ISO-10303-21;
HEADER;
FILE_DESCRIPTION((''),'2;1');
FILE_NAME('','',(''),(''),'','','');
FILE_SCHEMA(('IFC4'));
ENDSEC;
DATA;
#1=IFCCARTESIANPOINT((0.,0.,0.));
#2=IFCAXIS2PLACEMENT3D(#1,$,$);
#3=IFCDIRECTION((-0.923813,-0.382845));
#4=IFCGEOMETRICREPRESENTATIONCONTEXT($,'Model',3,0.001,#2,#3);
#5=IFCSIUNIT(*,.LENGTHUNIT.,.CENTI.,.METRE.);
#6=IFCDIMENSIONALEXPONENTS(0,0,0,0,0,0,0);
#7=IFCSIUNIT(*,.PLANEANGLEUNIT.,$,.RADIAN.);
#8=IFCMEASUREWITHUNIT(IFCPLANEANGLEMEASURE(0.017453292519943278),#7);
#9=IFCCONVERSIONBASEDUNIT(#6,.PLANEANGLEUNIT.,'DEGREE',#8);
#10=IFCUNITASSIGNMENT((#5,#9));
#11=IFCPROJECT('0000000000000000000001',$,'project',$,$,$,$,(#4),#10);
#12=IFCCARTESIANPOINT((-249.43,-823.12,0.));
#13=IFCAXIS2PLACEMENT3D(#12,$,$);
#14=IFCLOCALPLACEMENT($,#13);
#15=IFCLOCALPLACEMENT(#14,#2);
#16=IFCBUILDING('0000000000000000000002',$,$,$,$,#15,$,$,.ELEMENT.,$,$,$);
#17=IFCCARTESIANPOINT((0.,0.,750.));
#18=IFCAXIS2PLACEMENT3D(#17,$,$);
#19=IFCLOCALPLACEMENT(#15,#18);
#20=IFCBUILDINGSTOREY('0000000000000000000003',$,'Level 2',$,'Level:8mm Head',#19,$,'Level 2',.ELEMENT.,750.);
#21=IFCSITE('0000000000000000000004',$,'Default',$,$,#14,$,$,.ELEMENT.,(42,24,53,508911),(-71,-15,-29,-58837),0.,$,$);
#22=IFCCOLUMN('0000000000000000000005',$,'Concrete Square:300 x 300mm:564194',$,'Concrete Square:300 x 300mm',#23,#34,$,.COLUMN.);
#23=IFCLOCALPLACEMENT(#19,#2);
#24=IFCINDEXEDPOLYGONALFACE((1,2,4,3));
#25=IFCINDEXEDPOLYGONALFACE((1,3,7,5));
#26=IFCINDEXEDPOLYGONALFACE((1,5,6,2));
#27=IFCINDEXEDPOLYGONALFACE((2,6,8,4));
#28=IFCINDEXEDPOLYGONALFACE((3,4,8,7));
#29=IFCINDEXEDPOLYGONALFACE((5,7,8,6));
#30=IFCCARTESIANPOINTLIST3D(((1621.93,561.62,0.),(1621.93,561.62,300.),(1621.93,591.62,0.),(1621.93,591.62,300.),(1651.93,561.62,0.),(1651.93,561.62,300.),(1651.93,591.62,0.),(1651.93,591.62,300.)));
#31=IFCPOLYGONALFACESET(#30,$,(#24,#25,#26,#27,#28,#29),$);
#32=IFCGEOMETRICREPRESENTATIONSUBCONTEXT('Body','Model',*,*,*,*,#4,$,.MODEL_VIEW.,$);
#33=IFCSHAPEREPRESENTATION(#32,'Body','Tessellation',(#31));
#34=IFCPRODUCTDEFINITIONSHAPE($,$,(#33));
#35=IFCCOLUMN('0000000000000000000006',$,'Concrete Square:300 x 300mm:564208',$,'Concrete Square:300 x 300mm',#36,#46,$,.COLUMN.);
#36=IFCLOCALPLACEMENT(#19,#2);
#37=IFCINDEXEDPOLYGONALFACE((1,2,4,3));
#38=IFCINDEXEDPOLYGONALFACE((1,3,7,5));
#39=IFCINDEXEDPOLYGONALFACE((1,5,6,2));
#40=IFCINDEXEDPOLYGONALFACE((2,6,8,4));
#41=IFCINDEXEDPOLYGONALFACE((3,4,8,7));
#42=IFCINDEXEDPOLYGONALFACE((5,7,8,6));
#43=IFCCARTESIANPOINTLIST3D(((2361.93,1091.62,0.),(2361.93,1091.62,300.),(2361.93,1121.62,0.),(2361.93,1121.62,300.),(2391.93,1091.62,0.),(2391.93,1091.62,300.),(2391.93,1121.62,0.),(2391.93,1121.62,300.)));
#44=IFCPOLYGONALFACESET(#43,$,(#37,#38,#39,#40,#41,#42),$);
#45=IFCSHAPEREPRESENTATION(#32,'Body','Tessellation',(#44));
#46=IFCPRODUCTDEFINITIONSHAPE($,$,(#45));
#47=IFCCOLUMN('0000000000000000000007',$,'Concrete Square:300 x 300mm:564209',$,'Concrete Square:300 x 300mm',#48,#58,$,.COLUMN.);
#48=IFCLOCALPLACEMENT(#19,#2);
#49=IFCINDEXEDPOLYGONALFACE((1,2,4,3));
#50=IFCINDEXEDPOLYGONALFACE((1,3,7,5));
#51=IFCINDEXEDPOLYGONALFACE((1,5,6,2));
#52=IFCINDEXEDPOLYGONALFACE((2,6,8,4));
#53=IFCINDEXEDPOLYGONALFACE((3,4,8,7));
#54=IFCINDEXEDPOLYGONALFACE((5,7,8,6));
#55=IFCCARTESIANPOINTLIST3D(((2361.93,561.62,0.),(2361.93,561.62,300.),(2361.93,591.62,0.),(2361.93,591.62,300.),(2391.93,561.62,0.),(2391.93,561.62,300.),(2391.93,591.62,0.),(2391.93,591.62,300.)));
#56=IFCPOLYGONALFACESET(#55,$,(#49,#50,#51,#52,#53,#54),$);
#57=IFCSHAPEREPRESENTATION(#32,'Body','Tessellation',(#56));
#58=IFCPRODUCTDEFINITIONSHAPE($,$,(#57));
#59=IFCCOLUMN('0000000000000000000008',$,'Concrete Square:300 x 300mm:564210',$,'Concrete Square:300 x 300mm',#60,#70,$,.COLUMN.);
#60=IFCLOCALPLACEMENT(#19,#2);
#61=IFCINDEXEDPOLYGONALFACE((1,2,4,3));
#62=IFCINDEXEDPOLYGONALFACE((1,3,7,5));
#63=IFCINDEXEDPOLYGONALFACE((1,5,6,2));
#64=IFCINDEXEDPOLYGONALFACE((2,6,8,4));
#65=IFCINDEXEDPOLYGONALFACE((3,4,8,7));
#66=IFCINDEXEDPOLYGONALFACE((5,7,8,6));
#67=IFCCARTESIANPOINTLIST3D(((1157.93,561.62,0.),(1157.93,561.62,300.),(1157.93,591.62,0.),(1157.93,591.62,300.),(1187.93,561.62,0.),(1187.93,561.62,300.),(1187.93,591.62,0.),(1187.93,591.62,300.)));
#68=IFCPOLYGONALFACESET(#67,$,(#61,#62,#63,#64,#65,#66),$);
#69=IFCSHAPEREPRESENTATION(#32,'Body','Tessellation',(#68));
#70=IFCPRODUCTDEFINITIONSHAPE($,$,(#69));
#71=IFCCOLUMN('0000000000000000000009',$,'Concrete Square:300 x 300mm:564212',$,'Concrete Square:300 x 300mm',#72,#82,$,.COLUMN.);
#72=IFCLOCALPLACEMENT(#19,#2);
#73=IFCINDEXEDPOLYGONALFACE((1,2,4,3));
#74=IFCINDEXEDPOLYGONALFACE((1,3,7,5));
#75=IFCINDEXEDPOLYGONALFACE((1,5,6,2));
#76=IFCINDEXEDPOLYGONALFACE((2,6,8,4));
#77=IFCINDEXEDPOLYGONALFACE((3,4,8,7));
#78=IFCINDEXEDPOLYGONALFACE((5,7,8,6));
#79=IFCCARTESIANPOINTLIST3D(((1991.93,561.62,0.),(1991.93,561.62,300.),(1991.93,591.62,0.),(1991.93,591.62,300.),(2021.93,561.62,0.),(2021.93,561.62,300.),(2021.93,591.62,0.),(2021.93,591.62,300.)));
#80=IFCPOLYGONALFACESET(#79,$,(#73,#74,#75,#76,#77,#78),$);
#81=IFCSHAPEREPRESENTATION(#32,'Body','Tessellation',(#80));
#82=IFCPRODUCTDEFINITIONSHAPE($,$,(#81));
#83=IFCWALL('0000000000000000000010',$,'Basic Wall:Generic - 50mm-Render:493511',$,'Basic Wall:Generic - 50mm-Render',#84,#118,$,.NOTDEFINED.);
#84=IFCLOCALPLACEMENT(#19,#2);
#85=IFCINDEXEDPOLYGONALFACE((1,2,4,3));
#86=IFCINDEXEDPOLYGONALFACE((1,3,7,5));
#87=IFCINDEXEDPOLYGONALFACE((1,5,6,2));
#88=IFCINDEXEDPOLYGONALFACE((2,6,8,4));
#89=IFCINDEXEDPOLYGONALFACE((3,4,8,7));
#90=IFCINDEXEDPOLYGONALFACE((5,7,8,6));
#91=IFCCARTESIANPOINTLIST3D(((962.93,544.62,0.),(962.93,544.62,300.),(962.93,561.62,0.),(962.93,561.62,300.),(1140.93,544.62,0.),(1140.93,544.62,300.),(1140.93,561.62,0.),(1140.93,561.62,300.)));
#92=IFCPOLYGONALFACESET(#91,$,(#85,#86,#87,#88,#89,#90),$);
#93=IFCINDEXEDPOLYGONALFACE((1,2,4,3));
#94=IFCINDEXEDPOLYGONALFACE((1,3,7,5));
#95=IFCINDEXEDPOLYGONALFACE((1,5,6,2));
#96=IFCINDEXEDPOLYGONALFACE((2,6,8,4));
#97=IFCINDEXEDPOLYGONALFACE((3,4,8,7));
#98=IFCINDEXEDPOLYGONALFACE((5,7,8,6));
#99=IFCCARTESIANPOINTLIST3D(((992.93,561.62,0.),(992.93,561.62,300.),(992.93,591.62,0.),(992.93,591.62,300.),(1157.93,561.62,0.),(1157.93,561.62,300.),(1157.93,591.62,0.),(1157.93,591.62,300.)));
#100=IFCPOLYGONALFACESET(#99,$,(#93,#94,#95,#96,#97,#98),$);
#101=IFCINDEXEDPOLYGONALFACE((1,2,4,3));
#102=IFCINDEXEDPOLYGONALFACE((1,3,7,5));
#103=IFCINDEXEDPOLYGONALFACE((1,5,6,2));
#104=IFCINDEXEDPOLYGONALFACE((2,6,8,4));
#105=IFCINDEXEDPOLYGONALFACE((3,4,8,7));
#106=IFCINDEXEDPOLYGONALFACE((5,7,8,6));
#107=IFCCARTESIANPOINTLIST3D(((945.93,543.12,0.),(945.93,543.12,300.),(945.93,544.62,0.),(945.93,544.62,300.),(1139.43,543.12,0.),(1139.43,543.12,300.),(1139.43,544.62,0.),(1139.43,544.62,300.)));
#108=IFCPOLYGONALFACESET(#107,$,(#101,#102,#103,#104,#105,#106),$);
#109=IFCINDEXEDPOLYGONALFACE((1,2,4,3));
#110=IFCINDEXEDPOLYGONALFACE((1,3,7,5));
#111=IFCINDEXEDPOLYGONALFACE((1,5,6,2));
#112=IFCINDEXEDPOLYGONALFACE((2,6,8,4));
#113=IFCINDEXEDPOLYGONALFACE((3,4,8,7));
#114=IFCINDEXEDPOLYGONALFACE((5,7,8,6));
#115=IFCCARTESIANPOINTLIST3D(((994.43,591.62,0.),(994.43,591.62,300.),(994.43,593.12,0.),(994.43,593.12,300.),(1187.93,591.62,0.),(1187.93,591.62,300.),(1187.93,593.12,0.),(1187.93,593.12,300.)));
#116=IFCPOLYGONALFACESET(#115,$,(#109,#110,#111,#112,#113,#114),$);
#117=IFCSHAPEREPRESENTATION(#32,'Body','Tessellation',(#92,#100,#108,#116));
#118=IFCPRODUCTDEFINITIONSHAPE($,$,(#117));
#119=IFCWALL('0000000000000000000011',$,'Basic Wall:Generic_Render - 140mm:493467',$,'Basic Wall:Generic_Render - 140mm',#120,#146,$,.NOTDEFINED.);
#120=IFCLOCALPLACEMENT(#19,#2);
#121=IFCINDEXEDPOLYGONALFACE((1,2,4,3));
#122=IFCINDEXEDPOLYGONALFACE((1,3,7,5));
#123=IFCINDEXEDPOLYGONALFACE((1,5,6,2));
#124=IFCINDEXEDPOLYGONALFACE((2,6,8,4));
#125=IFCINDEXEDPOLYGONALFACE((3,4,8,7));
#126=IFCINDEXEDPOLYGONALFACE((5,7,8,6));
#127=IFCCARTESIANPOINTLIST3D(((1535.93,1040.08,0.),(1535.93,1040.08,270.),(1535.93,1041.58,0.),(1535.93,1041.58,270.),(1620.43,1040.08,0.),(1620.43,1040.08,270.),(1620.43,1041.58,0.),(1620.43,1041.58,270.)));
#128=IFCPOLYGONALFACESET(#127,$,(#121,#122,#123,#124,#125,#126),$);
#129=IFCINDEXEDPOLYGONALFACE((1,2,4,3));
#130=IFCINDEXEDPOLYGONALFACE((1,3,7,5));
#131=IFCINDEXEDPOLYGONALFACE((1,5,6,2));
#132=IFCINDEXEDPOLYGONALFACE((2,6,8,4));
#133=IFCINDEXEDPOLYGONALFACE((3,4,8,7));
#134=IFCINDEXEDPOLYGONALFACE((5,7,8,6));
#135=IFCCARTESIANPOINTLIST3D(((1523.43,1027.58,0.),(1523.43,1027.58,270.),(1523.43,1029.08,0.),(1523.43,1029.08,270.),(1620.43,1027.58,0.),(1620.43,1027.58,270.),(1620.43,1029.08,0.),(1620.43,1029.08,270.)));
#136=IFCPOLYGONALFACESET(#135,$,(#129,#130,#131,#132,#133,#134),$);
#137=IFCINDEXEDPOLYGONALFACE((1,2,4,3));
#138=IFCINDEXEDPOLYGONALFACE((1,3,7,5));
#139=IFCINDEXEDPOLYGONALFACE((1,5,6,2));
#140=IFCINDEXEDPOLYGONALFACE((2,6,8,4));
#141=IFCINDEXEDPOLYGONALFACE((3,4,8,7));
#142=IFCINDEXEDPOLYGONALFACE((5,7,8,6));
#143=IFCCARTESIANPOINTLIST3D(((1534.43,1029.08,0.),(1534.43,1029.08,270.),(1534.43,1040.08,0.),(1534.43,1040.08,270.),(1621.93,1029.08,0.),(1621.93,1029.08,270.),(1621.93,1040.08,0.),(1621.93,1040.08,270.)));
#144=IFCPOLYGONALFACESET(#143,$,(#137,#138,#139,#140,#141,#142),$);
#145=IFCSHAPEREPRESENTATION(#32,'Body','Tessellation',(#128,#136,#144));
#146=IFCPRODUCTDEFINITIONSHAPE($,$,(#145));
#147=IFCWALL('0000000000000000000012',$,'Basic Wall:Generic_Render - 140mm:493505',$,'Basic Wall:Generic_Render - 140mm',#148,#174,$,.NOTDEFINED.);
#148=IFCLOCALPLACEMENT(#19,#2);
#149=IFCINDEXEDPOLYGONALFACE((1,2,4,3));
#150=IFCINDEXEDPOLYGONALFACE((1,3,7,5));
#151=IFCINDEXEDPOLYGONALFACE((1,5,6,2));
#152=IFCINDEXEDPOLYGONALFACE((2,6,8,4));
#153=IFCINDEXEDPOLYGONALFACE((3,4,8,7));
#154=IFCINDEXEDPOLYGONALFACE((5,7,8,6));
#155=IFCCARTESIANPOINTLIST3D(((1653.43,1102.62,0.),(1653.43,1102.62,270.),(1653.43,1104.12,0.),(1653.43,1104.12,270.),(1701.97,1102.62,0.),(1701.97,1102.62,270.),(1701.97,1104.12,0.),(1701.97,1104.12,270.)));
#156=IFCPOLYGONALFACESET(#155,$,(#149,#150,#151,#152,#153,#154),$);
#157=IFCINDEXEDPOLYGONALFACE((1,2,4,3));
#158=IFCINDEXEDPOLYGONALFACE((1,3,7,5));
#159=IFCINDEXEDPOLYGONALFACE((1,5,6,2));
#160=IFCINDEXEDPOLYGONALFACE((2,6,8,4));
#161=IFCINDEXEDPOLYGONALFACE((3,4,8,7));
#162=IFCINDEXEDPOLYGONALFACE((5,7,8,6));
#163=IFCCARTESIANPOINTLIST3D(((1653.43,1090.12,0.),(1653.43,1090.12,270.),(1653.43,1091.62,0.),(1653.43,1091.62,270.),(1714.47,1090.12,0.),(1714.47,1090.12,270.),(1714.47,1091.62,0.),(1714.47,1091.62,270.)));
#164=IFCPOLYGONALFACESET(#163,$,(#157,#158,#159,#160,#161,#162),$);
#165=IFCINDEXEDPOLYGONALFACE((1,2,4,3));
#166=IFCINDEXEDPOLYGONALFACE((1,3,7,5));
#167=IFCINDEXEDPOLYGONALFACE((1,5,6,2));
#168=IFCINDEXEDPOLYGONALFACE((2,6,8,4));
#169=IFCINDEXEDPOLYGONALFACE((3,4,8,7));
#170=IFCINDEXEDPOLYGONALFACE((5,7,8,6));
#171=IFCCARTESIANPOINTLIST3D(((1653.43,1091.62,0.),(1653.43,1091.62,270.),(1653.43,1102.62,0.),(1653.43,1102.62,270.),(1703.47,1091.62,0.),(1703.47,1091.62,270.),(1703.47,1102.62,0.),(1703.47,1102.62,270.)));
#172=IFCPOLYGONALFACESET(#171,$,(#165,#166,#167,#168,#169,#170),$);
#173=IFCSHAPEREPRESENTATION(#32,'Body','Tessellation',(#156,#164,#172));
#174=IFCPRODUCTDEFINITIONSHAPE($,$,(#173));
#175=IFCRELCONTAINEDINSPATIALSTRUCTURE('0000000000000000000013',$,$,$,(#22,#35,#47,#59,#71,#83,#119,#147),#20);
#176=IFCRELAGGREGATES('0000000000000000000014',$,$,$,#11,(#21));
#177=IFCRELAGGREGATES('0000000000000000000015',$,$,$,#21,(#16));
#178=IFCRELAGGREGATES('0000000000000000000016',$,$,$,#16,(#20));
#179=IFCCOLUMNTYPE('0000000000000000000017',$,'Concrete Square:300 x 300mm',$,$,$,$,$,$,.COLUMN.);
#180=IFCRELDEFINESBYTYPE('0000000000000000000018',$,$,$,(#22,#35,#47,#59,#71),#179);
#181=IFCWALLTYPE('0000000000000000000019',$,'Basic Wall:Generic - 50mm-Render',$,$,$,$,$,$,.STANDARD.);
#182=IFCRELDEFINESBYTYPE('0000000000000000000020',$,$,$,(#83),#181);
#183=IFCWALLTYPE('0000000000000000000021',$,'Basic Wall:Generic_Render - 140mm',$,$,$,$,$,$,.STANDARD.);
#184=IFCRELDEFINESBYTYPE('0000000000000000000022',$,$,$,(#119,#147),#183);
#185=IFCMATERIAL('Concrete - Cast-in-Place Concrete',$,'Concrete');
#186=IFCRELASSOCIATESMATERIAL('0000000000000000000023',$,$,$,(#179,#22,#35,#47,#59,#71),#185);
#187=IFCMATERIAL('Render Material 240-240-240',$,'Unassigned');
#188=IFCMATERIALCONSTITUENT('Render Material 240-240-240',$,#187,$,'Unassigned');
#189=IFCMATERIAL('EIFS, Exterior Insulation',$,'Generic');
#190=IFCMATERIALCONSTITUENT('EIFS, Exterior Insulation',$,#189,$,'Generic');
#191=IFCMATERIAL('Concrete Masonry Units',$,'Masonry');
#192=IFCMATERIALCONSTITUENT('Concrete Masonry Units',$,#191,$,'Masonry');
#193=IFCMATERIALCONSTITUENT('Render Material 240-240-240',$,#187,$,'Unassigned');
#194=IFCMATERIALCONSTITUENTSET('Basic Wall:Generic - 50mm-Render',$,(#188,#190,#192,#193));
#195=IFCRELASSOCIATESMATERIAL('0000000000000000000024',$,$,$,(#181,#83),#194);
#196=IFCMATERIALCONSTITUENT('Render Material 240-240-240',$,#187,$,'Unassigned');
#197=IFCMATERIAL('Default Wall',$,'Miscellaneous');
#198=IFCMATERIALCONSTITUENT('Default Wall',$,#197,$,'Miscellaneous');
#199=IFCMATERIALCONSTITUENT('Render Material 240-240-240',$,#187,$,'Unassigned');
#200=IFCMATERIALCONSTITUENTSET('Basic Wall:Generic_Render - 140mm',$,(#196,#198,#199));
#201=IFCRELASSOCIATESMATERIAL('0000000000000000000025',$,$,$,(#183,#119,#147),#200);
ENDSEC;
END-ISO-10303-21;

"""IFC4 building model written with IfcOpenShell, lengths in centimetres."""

from ifc_helpers import new_model, entity, si_unit, converted_unit, direction, frame, origin, place, context, subcontext, project, spatial, indexed_curve, outline, extrude, source, transform, mapped, material, constituent, constituent_set, type_object, type_shapes, element, save


model = new_model("IFC4")

# Units and contexts
model_context = context("Model", 3, precision=0.001, world=origin(), true_north=direction((-0.923813, -0.382845)))
body_context = subcontext(model_context, "Body", "Model", "MODEL_VIEW")
ifc_project = project(units=[si_unit("LENGTHUNIT", "METRE", prefix="CENTI"), converted_unit("PLANEANGLEUNIT", "DEGREE", entity("IfcPlaneAngleMeasure", 0.017453292519943278), si_unit("PLANEANGLEUNIT", "RADIAN"), dimensions=[0, 0, 0, 0, 0, 0, 0])], contexts=[model_context])

# Site, building, storey
site_placement = place(None, frame((-249.43, -823.12, 0.0)))
site = spatial("IfcSite", under=ifc_project, at=site_placement, Name="Default", CompositionType="ELEMENT", RefLatitude=(42, 24, 53, 508911), RefLongitude=(-71, -15, -29, -58837), RefElevation=0.0)
building_placement = place(site_placement, origin())
building = spatial("IfcBuilding", under=site, at=building_placement, CompositionType="ELEMENT")
storey_placement = place(building_placement, frame((0.0, 0.0, 750.0)))
storey = spatial("IfcBuildingStorey", under=building, at=storey_placement, Name="Level 2", ObjectType="Level:8mm Head", LongName="Level 2", CompositionType="ELEMENT", Elevation=750.0)

# Columns
ifc_material_1 = material(Name="Concrete - Cast-in-Place Concrete", Category="Concrete")
column_type = type_object("IfcColumnType", Name="Concrete Square:300 x 300mm", PredefinedType="COLUMN", material=ifc_material_1)
shared_shape_1 = source(origin(), body_context, "Body", "SweptSolid", [
    extrude(outline(indexed_curve([(-15.0, -15.0), (15.0, -15.0), (15.0, 15.0), (-15.0, 15.0), (-15.0, -15.0)], self_intersect=False)), frame((0.0, 0.0, 750.0), z_axis=(0.0, 0.0, 1.0), x_axis=(-1.0, 0.0, 0.0)), (0.0, 0.0, 1.0), 300.0),
])
type_shapes(column_type, [shared_shape_1])
for number, where, name in (
    (1, (1636.93, 576.62, -750.0), "Concrete Square:300 x 300mm:564194"),
    (2, (2376.93, 1106.62, -750.0), "Concrete Square:300 x 300mm:564208"),
    (3, (2376.93, 576.62, -750.0), "Concrete Square:300 x 300mm:564209"),
    (4, (1172.93, 576.62, -750.0), "Concrete Square:300 x 300mm:564210"),
    (5, (2006.93, 576.62, -750.0), "Concrete Square:300 x 300mm:564212"),
):
    element("IfcColumn", number, at=place(storey_placement, frame(where)), inside=storey, type_object=column_type, material=ifc_material_1, Name=name, ObjectType="Concrete Square:300 x 300mm", PredefinedType="COLUMN", context=body_context, shape_type="MappedRepresentation", body=[
        mapped(shared_shape_1, transform((0.0, 0.0, 0.0), scale=1.0)),
    ])

# Walls
ifc_material_2 = material(Name="Render Material 240-240-240", Category="Unassigned")
ifc_material_3 = material(Name="Default Wall", Category="Miscellaneous")
ifc_constituent_1 = constituent(ifc_material_2, Name="Render Material 240-240-240", Category="Unassigned")
ifc_material_4 = material(Name="EIFS, Exterior Insulation", Category="Generic")
ifc_constituent_2 = constituent(ifc_material_4, Name="EIFS, Exterior Insulation", Category="Generic")
ifc_material_5 = material(Name="Concrete Masonry Units", Category="Masonry")
ifc_constituent_3 = constituent(ifc_material_5, Name="Concrete Masonry Units", Category="Masonry")
ifc_constituent_4 = constituent(ifc_material_2, Name="Render Material 240-240-240", Category="Unassigned")
ifc_constituent_set_1 = constituent_set(constituents=[ifc_constituent_1, ifc_constituent_2, ifc_constituent_3, ifc_constituent_4], Name="Basic Wall:Generic - 50mm-Render")
wall_type_1 = type_object("IfcWallType", Name="Basic Wall:Generic - 50mm-Render", PredefinedType="STANDARD", material=ifc_constituent_set_1)
wall_1_placement = place(storey_placement, frame((1139.43, 568.12, 0.0), z_axis=(0.0, 0.0, 1.0), x_axis=(-1.0, 0.0, 0.0)))
element("IfcWall", 6, at=wall_1_placement, inside=storey, type_object=wall_type_1, material=ifc_constituent_set_1, Name="Basic Wall:Generic - 50mm-Render:493511", ObjectType="Basic Wall:Generic - 50mm-Render", PredefinedType="NOTDEFINED", context=body_context, shape_type="SweptSolid", body=[
    extrude(outline(indexed_curve([(-89.0, -8.5), (89.0, -8.5), (89.0, 8.5), (-89.0, 8.5), (-89.0, -8.5)], self_intersect=False)), frame((87.5, 15.0, 0.0)), (0.0, 0.0, 1.0), 300.0),
    extrude(outline(indexed_curve([(-82.5, -15.0), (82.5, -15.0), (82.5, 15.0), (-82.5, 15.0), (-82.5, -15.0)], self_intersect=False)), frame((64.0, -8.5, 0.0)), (0.0, 0.0, 1.0), 300.0),
    extrude(outline(indexed_curve([(-0.75, -96.75), (0.75, -96.75), (0.75, 96.75), (-0.75, 96.75), (-0.75, -96.75)], self_intersect=False)), frame((96.75, 24.25, 0.0), z_axis=(0.0, 0.0, 1.0), x_axis=(0.0, -1.0, 0.0)), (0.0, 0.0, 1.0), 300.0),
    extrude(outline(indexed_curve([(-0.75, -96.75), (0.75, -96.75), (0.75, 96.75), (-0.75, 96.75), (-0.75, -96.75)], self_intersect=False)), frame((48.25, -24.25, 0.0), z_axis=(0.0, 0.0, 1.0), x_axis=(0.0, 1.0, 0.0)), (0.0, 0.0, 1.0), 300.0),
])
ifc_constituent_5 = constituent(ifc_material_2, Name="Render Material 240-240-240", Category="Unassigned")
ifc_constituent_6 = constituent(ifc_material_3, Name="Default Wall", Category="Miscellaneous")
ifc_constituent_7 = constituent(ifc_material_2, Name="Render Material 240-240-240", Category="Unassigned")
ifc_constituent_set_2 = constituent_set(constituents=[ifc_constituent_5, ifc_constituent_6, ifc_constituent_7], Name="Basic Wall:Generic_Render - 140mm")
wall_type_2 = type_object("IfcWallType", Name="Basic Wall:Generic_Render - 140mm", PredefinedType="STANDARD", material=ifc_constituent_set_2)
wall_2_placement = place(storey_placement, frame((1535.93, 1034.58, 0.0)))
element("IfcWall", 7, at=wall_2_placement, inside=storey, type_object=wall_type_2, material=ifc_constituent_set_2, Name="Basic Wall:Generic_Render - 140mm:493467", ObjectType="Basic Wall:Generic_Render - 140mm", PredefinedType="NOTDEFINED", context=body_context, shape_type="SweptSolid", body=[
    extrude(outline(indexed_curve([(-0.75, -42.25), (0.75, -42.25), (0.75, 42.25), (-0.75, 42.25), (-0.75, -42.25)], self_intersect=False)), frame((42.25, 6.25, 0.0), z_axis=(0.0, 0.0, 1.0), x_axis=(0.0, -1.0, 0.0)), (0.0, 0.0, 1.0), 270.0),
    extrude(outline(indexed_curve([(-0.75, -48.5), (0.75, -48.5), (0.75, 48.5), (-0.75, 48.5), (-0.75, -48.5)], self_intersect=False)), frame((36.0, -6.25, 0.0), z_axis=(0.0, 0.0, 1.0), x_axis=(0.0, 1.0, 0.0)), (0.0, 0.0, 1.0), 270.0),
    extrude(outline(indexed_curve([(-43.75, -5.5), (43.75, -5.5), (43.75, 5.5), (-43.75, 5.5), (-43.75, -5.5)], self_intersect=False)), frame((42.25, 0.0, 0.0)), (0.0, 0.0, 1.0), 270.0),
])
wall_3_placement = place(storey_placement, frame((1701.97, 1097.12, 0.0), z_axis=(0.0, 0.0, 1.0), x_axis=(-1.0, 0.0, 0.0)))
element("IfcWall", 8, at=wall_3_placement, inside=storey, type_object=wall_type_2, material=ifc_constituent_set_2, Name="Basic Wall:Generic_Render - 140mm:493505", ObjectType="Basic Wall:Generic_Render - 140mm", PredefinedType="NOTDEFINED", context=body_context, shape_type="SweptSolid", body=[
    extrude(outline(indexed_curve([(-0.75, -24.27), (0.75, -24.27), (0.75, 24.27), (-0.75, 24.27), (-0.75, -24.27)], self_intersect=False)), frame((24.27, -6.25, 0.0), z_axis=(0.0, 0.0, 1.0), x_axis=(0.0, 1.0, 0.0)), (0.0, 0.0, 1.0), 270.0),
    extrude(outline(indexed_curve([(-0.75, -30.52), (0.75, -30.52), (0.75, 30.52), (-0.75, 30.52), (-0.75, -30.52)], self_intersect=False)), frame((18.02, 6.25, 0.0), z_axis=(0.0, 0.0, 1.0), x_axis=(0.0, -1.0, 0.0)), (0.0, 0.0, 1.0), 270.0),
    extrude(outline(indexed_curve([(-25.02, -5.5), (25.02, -5.5), (25.02, 5.5), (-25.02, 5.5), (-25.02, -5.5)], self_intersect=False)), frame((23.52, 0.0, 0.0)), (0.0, 0.0, 1.0), 270.0),
])

save(model, "model.ifc")
